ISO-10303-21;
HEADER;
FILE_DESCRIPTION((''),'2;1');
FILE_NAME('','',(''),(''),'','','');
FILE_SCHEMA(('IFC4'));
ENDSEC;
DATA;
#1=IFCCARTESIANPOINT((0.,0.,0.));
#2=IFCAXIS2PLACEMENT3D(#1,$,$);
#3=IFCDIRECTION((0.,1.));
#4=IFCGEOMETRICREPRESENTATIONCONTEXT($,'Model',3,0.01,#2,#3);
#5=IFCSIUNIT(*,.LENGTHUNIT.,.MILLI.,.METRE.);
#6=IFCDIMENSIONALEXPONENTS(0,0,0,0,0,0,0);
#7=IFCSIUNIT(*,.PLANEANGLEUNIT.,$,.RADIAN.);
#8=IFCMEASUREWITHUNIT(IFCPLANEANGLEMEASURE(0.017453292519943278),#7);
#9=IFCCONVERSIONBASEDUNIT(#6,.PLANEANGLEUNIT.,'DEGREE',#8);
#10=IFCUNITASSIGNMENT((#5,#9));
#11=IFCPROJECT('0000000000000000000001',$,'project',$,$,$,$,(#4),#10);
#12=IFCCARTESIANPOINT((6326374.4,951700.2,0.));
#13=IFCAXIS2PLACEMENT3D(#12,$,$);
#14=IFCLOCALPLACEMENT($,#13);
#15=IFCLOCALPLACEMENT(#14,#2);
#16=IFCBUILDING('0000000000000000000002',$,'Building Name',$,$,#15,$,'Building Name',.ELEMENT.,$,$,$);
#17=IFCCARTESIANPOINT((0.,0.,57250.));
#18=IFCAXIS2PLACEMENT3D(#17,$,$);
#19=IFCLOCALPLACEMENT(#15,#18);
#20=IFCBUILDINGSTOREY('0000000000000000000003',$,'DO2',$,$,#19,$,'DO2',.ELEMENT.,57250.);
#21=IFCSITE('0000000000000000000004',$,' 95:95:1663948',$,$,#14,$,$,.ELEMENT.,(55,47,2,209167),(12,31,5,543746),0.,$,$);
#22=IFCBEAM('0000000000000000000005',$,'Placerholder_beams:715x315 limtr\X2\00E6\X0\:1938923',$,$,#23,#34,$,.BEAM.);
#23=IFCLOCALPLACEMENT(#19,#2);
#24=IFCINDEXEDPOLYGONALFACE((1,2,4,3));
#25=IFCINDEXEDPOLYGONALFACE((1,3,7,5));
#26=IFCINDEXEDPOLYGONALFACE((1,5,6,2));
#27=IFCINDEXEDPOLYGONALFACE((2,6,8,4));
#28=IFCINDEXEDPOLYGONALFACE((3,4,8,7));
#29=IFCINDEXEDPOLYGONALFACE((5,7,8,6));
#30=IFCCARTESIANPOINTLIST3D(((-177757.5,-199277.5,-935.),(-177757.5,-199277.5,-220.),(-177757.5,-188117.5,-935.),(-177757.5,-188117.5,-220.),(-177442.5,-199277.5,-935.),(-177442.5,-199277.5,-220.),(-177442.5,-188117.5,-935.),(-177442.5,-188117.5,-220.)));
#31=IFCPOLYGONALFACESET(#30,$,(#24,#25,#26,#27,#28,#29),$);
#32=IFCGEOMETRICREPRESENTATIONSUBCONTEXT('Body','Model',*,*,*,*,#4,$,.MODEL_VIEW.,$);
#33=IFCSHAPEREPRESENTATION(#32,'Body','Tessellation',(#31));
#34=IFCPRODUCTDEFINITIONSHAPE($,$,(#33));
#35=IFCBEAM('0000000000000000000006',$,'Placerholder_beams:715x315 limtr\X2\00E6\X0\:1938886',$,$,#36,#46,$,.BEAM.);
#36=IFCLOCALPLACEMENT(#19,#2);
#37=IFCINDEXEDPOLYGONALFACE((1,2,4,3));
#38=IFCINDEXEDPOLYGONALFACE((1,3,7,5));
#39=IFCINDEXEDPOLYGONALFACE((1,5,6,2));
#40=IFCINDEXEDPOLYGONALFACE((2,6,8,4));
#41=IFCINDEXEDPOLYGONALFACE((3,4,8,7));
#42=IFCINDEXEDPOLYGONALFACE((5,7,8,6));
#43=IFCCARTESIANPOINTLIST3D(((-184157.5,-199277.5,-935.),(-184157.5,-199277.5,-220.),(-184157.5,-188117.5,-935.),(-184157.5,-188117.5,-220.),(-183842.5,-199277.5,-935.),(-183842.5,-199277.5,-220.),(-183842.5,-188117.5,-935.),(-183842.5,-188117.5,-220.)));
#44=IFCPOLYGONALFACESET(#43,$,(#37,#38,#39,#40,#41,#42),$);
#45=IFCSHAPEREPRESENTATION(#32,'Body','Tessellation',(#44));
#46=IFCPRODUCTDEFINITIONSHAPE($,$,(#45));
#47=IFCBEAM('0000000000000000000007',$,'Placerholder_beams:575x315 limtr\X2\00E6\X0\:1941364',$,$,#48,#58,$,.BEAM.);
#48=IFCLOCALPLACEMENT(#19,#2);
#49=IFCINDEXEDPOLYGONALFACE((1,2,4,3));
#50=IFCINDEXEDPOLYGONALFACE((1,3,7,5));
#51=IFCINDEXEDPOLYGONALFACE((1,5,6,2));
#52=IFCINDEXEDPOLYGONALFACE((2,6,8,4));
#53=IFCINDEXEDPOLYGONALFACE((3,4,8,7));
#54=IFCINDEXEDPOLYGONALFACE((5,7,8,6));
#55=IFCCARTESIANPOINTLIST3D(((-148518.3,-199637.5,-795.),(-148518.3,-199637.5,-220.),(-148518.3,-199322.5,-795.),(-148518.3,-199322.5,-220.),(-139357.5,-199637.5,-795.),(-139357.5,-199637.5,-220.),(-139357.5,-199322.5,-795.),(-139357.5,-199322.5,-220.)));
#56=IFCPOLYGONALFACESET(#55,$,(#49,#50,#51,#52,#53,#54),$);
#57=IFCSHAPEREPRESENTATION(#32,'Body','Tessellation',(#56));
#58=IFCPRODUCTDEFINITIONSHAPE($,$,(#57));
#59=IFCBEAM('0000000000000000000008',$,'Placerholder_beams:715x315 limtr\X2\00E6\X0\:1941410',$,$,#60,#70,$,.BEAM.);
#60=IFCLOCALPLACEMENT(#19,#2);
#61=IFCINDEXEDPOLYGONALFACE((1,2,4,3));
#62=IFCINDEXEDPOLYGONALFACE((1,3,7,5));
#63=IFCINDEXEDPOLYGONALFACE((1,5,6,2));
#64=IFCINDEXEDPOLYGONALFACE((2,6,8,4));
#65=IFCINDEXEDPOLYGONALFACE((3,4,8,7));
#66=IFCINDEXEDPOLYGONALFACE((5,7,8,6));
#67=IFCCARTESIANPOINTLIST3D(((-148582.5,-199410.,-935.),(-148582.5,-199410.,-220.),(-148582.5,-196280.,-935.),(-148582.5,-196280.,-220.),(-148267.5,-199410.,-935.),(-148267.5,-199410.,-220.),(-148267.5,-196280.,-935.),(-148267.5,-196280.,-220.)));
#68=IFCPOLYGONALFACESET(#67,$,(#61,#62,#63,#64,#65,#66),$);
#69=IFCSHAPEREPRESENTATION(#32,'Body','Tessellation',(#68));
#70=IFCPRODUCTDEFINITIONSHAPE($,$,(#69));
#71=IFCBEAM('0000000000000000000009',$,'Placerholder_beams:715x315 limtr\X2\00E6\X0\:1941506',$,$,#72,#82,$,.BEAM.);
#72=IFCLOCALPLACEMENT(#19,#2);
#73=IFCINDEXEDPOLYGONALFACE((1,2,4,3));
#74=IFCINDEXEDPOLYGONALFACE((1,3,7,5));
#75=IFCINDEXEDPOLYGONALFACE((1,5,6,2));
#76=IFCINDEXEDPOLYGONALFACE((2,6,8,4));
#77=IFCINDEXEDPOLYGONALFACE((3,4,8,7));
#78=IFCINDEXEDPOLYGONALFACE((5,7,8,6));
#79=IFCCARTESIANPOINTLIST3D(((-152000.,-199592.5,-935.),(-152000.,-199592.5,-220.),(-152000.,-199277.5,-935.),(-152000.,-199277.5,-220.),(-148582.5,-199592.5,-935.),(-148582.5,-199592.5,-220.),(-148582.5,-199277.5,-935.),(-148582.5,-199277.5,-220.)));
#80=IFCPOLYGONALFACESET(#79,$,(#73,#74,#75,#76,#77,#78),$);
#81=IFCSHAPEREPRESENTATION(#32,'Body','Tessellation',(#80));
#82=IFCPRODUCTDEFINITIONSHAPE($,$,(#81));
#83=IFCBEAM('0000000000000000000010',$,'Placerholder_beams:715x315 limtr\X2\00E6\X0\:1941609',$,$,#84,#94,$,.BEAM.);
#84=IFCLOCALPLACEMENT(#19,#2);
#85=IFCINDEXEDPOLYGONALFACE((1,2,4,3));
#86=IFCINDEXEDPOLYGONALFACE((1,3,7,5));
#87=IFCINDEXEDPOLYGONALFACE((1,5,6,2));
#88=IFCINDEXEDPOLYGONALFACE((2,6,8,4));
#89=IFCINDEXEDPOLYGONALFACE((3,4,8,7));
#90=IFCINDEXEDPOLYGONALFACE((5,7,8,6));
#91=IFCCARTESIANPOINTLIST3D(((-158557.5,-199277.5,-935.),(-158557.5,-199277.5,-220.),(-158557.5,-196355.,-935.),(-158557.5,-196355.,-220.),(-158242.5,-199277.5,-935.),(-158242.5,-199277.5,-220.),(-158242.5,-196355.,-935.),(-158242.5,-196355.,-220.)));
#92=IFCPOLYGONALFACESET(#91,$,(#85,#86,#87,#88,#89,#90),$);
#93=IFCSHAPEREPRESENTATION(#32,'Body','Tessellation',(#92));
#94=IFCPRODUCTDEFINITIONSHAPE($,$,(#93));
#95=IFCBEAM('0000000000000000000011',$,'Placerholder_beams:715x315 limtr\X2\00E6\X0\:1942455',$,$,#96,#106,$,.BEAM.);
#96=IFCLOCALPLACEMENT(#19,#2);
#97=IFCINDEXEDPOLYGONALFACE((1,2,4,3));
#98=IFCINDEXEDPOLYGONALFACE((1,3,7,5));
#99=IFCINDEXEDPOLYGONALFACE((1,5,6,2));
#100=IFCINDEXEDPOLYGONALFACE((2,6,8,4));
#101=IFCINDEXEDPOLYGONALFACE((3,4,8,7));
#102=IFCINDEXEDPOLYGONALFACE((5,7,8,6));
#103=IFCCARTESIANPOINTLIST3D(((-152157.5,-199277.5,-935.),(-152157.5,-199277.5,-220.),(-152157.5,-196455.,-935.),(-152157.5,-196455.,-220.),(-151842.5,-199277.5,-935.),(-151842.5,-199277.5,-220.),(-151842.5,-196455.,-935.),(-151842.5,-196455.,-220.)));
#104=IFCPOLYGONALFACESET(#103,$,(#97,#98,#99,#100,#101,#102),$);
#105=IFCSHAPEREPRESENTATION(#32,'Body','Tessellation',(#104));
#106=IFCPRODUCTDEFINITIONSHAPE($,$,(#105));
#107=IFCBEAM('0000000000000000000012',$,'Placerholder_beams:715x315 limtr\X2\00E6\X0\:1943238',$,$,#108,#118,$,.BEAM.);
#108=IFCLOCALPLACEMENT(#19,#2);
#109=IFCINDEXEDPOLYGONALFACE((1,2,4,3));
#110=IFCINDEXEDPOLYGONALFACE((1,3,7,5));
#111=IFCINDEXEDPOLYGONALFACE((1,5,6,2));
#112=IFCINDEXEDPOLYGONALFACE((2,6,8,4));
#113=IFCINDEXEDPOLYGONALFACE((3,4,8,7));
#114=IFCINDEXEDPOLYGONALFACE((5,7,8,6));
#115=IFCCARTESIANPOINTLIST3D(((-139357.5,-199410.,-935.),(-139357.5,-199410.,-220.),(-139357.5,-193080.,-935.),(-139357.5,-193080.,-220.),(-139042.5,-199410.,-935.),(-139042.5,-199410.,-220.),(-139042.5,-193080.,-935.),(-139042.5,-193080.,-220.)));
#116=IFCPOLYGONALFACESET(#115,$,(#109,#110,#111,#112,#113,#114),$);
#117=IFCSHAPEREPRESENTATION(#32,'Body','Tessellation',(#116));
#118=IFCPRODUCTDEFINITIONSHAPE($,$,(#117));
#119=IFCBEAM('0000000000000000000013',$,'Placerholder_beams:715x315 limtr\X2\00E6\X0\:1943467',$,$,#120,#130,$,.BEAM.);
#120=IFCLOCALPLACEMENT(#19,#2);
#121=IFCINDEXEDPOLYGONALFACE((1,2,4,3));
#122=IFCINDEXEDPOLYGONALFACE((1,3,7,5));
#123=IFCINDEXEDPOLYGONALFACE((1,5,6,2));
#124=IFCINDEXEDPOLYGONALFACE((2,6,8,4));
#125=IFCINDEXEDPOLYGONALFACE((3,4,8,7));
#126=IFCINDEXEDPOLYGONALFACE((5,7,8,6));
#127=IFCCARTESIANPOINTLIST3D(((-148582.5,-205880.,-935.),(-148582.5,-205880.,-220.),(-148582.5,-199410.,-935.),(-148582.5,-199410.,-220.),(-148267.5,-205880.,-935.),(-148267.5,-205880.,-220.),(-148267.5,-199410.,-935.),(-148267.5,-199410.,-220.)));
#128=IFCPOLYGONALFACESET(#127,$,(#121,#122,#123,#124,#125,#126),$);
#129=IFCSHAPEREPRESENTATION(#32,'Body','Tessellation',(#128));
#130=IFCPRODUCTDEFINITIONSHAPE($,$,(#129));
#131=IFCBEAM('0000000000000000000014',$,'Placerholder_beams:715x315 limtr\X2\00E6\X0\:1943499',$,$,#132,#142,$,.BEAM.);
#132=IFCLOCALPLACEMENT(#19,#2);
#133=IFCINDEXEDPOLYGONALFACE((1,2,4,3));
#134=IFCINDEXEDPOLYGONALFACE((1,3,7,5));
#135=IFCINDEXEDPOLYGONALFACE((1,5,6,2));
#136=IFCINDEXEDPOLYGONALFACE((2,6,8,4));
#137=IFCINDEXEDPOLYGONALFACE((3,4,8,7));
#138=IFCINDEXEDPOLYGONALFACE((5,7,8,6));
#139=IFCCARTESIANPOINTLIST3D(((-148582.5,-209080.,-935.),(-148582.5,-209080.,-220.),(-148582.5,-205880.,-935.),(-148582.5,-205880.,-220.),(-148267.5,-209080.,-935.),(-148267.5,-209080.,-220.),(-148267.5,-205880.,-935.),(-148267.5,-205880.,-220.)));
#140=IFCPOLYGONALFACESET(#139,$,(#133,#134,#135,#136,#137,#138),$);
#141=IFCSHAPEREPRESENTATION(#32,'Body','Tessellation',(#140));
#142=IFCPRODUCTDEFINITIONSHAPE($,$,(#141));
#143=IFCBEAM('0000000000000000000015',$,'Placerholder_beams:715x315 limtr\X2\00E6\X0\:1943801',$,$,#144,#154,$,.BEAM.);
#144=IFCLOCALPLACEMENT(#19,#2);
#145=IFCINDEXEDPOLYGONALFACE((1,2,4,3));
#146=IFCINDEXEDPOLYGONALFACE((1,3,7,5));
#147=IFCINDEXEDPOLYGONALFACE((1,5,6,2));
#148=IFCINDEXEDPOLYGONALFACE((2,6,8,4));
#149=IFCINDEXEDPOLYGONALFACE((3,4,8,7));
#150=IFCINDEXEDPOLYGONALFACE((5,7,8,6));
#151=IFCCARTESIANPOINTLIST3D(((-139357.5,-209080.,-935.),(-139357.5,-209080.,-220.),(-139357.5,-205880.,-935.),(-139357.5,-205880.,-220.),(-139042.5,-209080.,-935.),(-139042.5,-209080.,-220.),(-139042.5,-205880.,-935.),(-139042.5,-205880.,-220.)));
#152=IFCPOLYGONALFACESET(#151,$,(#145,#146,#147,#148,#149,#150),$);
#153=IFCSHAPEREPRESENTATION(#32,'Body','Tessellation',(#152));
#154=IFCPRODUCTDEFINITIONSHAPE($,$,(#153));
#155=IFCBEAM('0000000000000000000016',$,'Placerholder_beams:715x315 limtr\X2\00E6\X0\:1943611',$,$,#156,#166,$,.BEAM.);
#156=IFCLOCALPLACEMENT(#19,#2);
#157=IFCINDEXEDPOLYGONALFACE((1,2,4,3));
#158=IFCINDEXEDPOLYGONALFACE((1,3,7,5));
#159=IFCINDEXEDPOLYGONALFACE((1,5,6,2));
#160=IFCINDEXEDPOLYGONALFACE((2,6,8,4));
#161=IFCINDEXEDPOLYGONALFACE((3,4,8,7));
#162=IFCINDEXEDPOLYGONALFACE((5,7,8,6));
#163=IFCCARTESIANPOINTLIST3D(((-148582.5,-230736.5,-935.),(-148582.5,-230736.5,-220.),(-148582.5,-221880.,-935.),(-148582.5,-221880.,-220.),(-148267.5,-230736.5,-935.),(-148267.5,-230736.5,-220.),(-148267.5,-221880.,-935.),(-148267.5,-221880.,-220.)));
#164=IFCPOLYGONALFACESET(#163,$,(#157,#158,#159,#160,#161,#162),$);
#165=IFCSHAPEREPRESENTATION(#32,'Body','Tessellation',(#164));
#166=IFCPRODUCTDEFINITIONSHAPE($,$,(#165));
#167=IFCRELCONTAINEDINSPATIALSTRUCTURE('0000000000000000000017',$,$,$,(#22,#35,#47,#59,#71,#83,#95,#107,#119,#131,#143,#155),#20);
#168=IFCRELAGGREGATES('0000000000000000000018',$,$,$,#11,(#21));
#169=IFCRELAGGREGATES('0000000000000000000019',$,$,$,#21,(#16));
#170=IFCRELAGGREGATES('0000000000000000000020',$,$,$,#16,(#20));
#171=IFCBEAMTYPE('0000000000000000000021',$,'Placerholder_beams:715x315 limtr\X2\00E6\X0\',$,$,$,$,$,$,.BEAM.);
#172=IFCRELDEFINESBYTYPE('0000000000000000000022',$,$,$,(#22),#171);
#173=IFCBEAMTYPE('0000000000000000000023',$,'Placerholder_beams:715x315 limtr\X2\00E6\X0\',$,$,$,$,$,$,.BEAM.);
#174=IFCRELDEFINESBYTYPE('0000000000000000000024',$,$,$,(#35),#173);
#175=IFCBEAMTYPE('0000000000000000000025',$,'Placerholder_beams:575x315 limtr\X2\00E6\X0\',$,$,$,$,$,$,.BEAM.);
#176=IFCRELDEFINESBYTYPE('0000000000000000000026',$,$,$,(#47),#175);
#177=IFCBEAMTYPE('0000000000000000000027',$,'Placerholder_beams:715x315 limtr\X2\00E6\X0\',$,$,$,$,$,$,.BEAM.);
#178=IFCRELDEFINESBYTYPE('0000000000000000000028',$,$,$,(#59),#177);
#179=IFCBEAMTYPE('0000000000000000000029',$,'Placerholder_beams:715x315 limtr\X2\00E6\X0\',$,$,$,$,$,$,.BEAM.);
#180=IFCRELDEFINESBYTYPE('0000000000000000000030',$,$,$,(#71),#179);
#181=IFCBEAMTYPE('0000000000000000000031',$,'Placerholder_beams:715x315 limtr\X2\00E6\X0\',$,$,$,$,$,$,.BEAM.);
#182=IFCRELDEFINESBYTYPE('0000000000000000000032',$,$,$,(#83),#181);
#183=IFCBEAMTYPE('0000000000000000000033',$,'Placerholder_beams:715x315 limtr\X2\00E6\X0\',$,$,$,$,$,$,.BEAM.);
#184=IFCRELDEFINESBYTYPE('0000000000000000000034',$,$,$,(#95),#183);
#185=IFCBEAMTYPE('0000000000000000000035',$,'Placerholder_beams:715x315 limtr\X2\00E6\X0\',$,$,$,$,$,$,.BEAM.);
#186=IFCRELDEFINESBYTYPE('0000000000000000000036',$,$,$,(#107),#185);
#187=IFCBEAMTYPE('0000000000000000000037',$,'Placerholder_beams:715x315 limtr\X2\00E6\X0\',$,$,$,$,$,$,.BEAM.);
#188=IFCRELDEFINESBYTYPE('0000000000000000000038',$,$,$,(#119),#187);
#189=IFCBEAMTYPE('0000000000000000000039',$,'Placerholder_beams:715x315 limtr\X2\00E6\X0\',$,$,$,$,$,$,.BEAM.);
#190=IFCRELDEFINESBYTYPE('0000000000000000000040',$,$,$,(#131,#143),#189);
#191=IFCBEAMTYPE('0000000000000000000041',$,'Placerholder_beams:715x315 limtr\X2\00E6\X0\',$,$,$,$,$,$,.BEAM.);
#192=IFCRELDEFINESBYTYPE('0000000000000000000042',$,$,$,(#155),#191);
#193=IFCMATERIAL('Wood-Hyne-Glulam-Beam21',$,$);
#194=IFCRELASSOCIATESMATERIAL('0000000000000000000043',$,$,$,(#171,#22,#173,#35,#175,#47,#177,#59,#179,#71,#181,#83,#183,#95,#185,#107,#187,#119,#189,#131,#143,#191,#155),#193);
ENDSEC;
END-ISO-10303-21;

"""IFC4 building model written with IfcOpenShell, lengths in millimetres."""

from ifc_helpers import new_model, entity, si_unit, converted_unit, direction, frame, origin, place, context, subcontext, project, spatial, indexed_curve, outline, extrude, source, transform, mapped, material, type_object, type_shapes, element, save


model = new_model("IFC4")

# Units and contexts
model_context = context("Model", 3, precision=0.01, world=origin(), true_north=direction((0.0, 1.0)))
body_context = subcontext(model_context, "Body", "Model", "MODEL_VIEW")
ifc_project = project(units=[si_unit("LENGTHUNIT", "METRE", prefix="MILLI"), converted_unit("PLANEANGLEUNIT", "DEGREE", entity("IfcPlaneAngleMeasure", 0.017453292519943278), si_unit("PLANEANGLEUNIT", "RADIAN"), dimensions=[0, 0, 0, 0, 0, 0, 0])], contexts=[model_context])

# Site, building, storey
site_placement = place(None, frame((6326374.4, 951700.2, 0.0)))
site = spatial("IfcSite", under=ifc_project, at=site_placement, Name=" 95:95:1663948", CompositionType="ELEMENT", RefLatitude=(55, 47, 2, 209167), RefLongitude=(12, 31, 5, 543746), RefElevation=0.0)
building_placement = place(site_placement, origin())
building = spatial("IfcBuilding", under=site, at=building_placement, Name="Building Name", LongName="Building Name", CompositionType="ELEMENT")
storey_placement = place(building_placement, frame((0.0, 0.0, 57250.0)))
storey = spatial("IfcBuildingStorey", under=building, at=storey_placement, Name="DO2", LongName="DO2", CompositionType="ELEMENT", Elevation=57250.0)

# Beams
ifc_material = material(Name="Wood-Hyne-Glulam-Beam21")
beam_type_1 = type_object("IfcBeamType", Name="Placerholder_beams:715x315 limtræ", PredefinedType="BEAM", material=ifc_material)
shared_shape_1 = source(origin(), body_context, "Body", "SweptSolid", [
    extrude(outline(indexed_curve([(-5580.0, -157.5), (5580.0, -157.5), (5580.0, 157.5), (-5580.0, 157.5), (-5580.0, -157.5)], self_intersect=False)), frame((0.0, 0.0, -357.5)), (0.0, 0.0, 1.0), 715.0),
])
type_shapes(beam_type_1, [shared_shape_1])
for number, where, z_axis, x_axis, name in (
    (1, (-177600.0, -193697.5, -577.5), (0.0, 0.0, 1.0), (0.0, 1.0, 0.0), "Placerholder_beams:715x315 limtræ:1938923"),
):
    element("IfcBeam", number, at=place(storey_placement, frame(where, z_axis=z_axis, x_axis=x_axis)), inside=storey, type_object=beam_type_1, material=ifc_material, Name=name, PredefinedType="BEAM", context=body_context, shape_type="MappedRepresentation", body=[
        mapped(shared_shape_1, transform((0.0, 0.0, 0.0), scale=1.0)),
    ])
beam_type_2 = type_object("IfcBeamType", Name="Placerholder_beams:715x315 limtræ", PredefinedType="BEAM", material=ifc_material)
shared_shape_2 = source(origin(), body_context, "Body", "SweptSolid", [
    extrude(outline(indexed_curve([(-5580.0, -157.5), (5580.0, -157.5), (5580.0, 157.5), (-5580.0, 157.5), (-5580.0, -157.5)], self_intersect=False)), frame((22.5, 0.0, -357.5)), (0.0, 0.0, 1.0), 715.0),
])
type_shapes(beam_type_2, [shared_shape_2])
beam_1_placement = place(storey_placement, frame((-184000.0, -193720.0, -577.5), z_axis=(0.0, 0.0, 1.0), x_axis=(0.0, 1.0, 0.0)))
element("IfcBeam", 2, at=beam_1_placement, inside=storey, type_object=beam_type_2, material=ifc_material, Name="Placerholder_beams:715x315 limtræ:1938886", PredefinedType="BEAM", context=body_context, shape_type="MappedRepresentation", body=[
    mapped(shared_shape_2, transform((0.0, 0.0, 0.0), scale=1.0)),
])
beam_type_3 = type_object("IfcBeamType", Name="Placerholder_beams:575x315 limtræ", PredefinedType="BEAM", material=ifc_material)
shared_shape_3 = source(origin(), body_context, "Body", "SweptSolid", [
    extrude(outline(indexed_curve([(-4580.4, -157.5), (4580.4, -157.5), (4580.4, 157.5), (-4580.4, 157.5), (-4580.4, -157.5)], self_intersect=False)), frame((-125.4, 0.0, -287.5)), (0.0, 0.0, 1.0), 575.0),
])
type_shapes(beam_type_3, [shared_shape_3])
beam_2_placement = place(storey_placement, frame((-143812.5, -199480.0, -507.5)))
element("IfcBeam", 3, at=beam_2_placement, inside=storey, type_object=beam_type_3, material=ifc_material, Name="Placerholder_beams:575x315 limtræ:1941364", PredefinedType="BEAM", context=body_context, shape_type="MappedRepresentation", body=[
    mapped(shared_shape_3, transform((0.0, 0.0, 0.0), scale=1.0)),
])
beam_type_4 = type_object("IfcBeamType", Name="Placerholder_beams:715x315 limtræ", PredefinedType="BEAM", material=ifc_material)
shared_shape_4 = source(origin(), body_context, "Body", "SweptSolid", [
    extrude(outline(indexed_curve([(-1565.0, -157.5), (1565.0, -157.5), (1565.0, 157.5), (-1565.0, 157.5), (-1565.0, -157.5)], self_intersect=False)), frame((35.0, 0.0, -357.5)), (0.0, 0.0, 1.0), 715.0),
])
type_shapes(beam_type_4, [shared_shape_4])
beam_3_placement = place(storey_placement, frame((-148425.0, -197880.0, -577.5), z_axis=(0.0, 0.0, 1.0), x_axis=(0.0, 1.0, 0.0)))
element("IfcBeam", 4, at=beam_3_placement, inside=storey, type_object=beam_type_4, material=ifc_material, Name="Placerholder_beams:715x315 limtræ:1941410", PredefinedType="BEAM", context=body_context, shape_type="MappedRepresentation", body=[
    mapped(shared_shape_4, transform((0.0, 0.0, 0.0), scale=1.0)),
])
beam_type_5 = type_object("IfcBeamType", Name="Placerholder_beams:715x315 limtræ", PredefinedType="BEAM", material=ifc_material)
shared_shape_5 = source(origin(), body_context, "Body", "SweptSolid", [
    extrude(outline(indexed_curve([(-1708.8, -157.5), (1708.8, -157.5), (1708.8, 157.5), (-1708.8, 157.5), (-1708.8, -157.5)], self_intersect=False)), frame((78.8, 0.0, -357.5)), (0.0, 0.0, 1.0), 715.0),
])
type_shapes(beam_type_5, [shared_shape_5])
beam_4_placement = place(storey_placement, frame((-150212.5, -199435.0, -577.5), z_axis=(0.0, 0.0, 1.0), x_axis=(-1.0, 0.0, 0.0)))
element("IfcBeam", 5, at=beam_4_placement, inside=storey, type_object=beam_type_5, material=ifc_material, Name="Placerholder_beams:715x315 limtræ:1941506", PredefinedType="BEAM", context=body_context, shape_type="MappedRepresentation", body=[
    mapped(shared_shape_5, transform((0.0, 0.0, 0.0), scale=1.0)),
])
beam_type_6 = type_object("IfcBeamType", Name="Placerholder_beams:715x315 limtræ", PredefinedType="BEAM", material=ifc_material)
shared_shape_6 = source(origin(), body_context, "Body", "SweptSolid", [
    extrude(outline(indexed_curve([(-1461.2, -157.5), (1461.2, -157.5), (1461.2, 157.5), (-1461.2, 157.5), (-1461.2, -157.5)], self_intersect=False)), frame((78.7, 0.0, -357.5)), (0.0, 0.0, 1.0), 715.0),
])
type_shapes(beam_type_6, [shared_shape_6])
beam_5_placement = place(storey_placement, frame((-158400.0, -197895.0, -577.5), z_axis=(0.0, 0.0, 1.0), x_axis=(0.0, 1.0, 0.0)))
element("IfcBeam", 6, at=beam_5_placement, inside=storey, type_object=beam_type_6, material=ifc_material, Name="Placerholder_beams:715x315 limtræ:1941609", PredefinedType="BEAM", context=body_context, shape_type="MappedRepresentation", body=[
    mapped(shared_shape_6, transform((0.0, 0.0, 0.0), scale=1.0)),
])
beam_type_7 = type_object("IfcBeamType", Name="Placerholder_beams:715x315 limtræ", PredefinedType="BEAM", material=ifc_material)
shared_shape_7 = source(origin(), body_context, "Body", "SweptSolid", [
    extrude(outline(indexed_curve([(-1411.2, -157.5), (1411.2, -157.5), (1411.2, 157.5), (-1411.2, 157.5), (-1411.2, -157.5)], self_intersect=False)), frame((28.8, 0.0, -357.5)), (0.0, 0.0, 1.0), 715.0),
])
type_shapes(beam_type_7, [shared_shape_7])
beam_6_placement = place(storey_placement, frame((-152000.0, -197895.0, -577.5), z_axis=(0.0, 0.0, 1.0), x_axis=(0.0, 1.0, 0.0)))
element("IfcBeam", 7, at=beam_6_placement, inside=storey, type_object=beam_type_7, material=ifc_material, Name="Placerholder_beams:715x315 limtræ:1942455", PredefinedType="BEAM", context=body_context, shape_type="MappedRepresentation", body=[
    mapped(shared_shape_7, transform((0.0, 0.0, 0.0), scale=1.0)),
])
beam_type_8 = type_object("IfcBeamType", Name="Placerholder_beams:715x315 limtræ", PredefinedType="BEAM", material=ifc_material)
shared_shape_8 = source(origin(), body_context, "Body", "SweptSolid", [
    extrude(outline(indexed_curve([(-3165.0, -157.5), (3165.0, -157.5), (3165.0, 157.5), (-3165.0, 157.5), (-3165.0, -157.5)], self_intersect=False)), frame((-35.0, 0.0, -357.5)), (0.0, 0.0, 1.0), 715.0),
])
type_shapes(beam_type_8, [shared_shape_8])
beam_7_placement = place(storey_placement, frame((-139200.0, -196280.0, -577.5), z_axis=(0.0, 0.0, 1.0), x_axis=(0.0, -1.0, 0.0)))
element("IfcBeam", 8, at=beam_7_placement, inside=storey, type_object=beam_type_8, material=ifc_material, Name="Placerholder_beams:715x315 limtræ:1943238", PredefinedType="BEAM", context=body_context, shape_type="MappedRepresentation", body=[
    mapped(shared_shape_8, transform((0.0, 0.0, 0.0), scale=1.0)),
])
beam_type_9 = type_object("IfcBeamType", Name="Placerholder_beams:715x315 limtræ", PredefinedType="BEAM", material=ifc_material)
shared_shape_9 = source(origin(), body_context, "Body", "SweptSolid", [
    extrude(outline(indexed_curve([(-3235.0, -157.5), (3235.0, -157.5), (3235.0, 157.5), (-3235.0, 157.5), (-3235.0, -157.5)], self_intersect=False)), frame((-1635.0, 0.0, -357.5)), (0.0, 0.0, 1.0), 715.0),
])
type_shapes(beam_type_9, [shared_shape_9])
beam_8_placement = place(storey_placement, frame((-148425.0, -204280.0, -577.5), z_axis=(0.0, 0.0, 1.0), x_axis=(0.0, -1.0, 0.0)))
element("IfcBeam", 9, at=beam_8_placement, inside=storey, type_object=beam_type_9, material=ifc_material, Name="Placerholder_beams:715x315 limtræ:1943467", PredefinedType="BEAM", context=body_context, shape_type="MappedRepresentation", body=[
    mapped(shared_shape_9, transform((0.0, 0.0, 0.0), scale=1.0)),
])
beam_type_10 = type_object("IfcBeamType", Name="Placerholder_beams:715x315 limtræ", PredefinedType="BEAM", material=ifc_material)
shared_shape_10 = source(origin(), body_context, "Body", "SweptSolid", [
    extrude(outline(indexed_curve([(-1600.0, -157.5), (1600.0, -157.5), (1600.0, 157.5), (-1600.0, 157.5), (-1600.0, -157.5)], self_intersect=False)), frame((0.0, 0.0, -357.5)), (0.0, 0.0, 1.0), 715.0),
])
type_shapes(beam_type_10, [shared_shape_10])
for number, where, z_axis, x_axis, name in (
    (10, (-148425.0, -207480.0, -577.5), (0.0, 0.0, 1.0), (0.0, -1.0, 0.0), "Placerholder_beams:715x315 limtræ:1943499"),
    (11, (-139200.0, -207480.0, -577.5), (0.0, 0.0, 1.0), (0.0, 1.0, 0.0), "Placerholder_beams:715x315 limtræ:1943801"),
):
    element("IfcBeam", number, at=place(storey_placement, frame(where, z_axis=z_axis, x_axis=x_axis)), inside=storey, type_object=beam_type_10, material=ifc_material, Name=name, PredefinedType="BEAM", context=body_context, shape_type="MappedRepresentation", body=[
        mapped(shared_shape_10, transform((0.0, 0.0, 0.0), scale=1.0)),
    ])
beam_type_11 = type_object("IfcBeamType", Name="Placerholder_beams:715x315 limtræ", PredefinedType="BEAM", material=ifc_material)
shared_shape_11 = source(origin(), body_context, "Body", "SweptSolid", [
    extrude(outline(indexed_curve([(-4428.2, -157.5), (4428.2, -157.5), (4428.2, 157.5), (-4428.2, 157.5), (-4428.2, -157.5)], self_intersect=False)), frame((78.8, 0.0, -357.5)), (0.0, 0.0, 1.0), 715.0),
])
type_shapes(beam_type_11, [shared_shape_11])
beam_9_placement = place(storey_placement, frame((-148425.0, -226229.5, -577.5), z_axis=(0.0, 0.0, 1.0), x_axis=(0.0, -1.0, 0.0)))
element("IfcBeam", 12, at=beam_9_placement, inside=storey, type_object=beam_type_11, material=ifc_material, Name="Placerholder_beams:715x315 limtræ:1943611", PredefinedType="BEAM", context=body_context, shape_type="MappedRepresentation", body=[
    mapped(shared_shape_11, transform((0.0, 0.0, 0.0), scale=1.0)),
])

save(model, "model.ifc")
